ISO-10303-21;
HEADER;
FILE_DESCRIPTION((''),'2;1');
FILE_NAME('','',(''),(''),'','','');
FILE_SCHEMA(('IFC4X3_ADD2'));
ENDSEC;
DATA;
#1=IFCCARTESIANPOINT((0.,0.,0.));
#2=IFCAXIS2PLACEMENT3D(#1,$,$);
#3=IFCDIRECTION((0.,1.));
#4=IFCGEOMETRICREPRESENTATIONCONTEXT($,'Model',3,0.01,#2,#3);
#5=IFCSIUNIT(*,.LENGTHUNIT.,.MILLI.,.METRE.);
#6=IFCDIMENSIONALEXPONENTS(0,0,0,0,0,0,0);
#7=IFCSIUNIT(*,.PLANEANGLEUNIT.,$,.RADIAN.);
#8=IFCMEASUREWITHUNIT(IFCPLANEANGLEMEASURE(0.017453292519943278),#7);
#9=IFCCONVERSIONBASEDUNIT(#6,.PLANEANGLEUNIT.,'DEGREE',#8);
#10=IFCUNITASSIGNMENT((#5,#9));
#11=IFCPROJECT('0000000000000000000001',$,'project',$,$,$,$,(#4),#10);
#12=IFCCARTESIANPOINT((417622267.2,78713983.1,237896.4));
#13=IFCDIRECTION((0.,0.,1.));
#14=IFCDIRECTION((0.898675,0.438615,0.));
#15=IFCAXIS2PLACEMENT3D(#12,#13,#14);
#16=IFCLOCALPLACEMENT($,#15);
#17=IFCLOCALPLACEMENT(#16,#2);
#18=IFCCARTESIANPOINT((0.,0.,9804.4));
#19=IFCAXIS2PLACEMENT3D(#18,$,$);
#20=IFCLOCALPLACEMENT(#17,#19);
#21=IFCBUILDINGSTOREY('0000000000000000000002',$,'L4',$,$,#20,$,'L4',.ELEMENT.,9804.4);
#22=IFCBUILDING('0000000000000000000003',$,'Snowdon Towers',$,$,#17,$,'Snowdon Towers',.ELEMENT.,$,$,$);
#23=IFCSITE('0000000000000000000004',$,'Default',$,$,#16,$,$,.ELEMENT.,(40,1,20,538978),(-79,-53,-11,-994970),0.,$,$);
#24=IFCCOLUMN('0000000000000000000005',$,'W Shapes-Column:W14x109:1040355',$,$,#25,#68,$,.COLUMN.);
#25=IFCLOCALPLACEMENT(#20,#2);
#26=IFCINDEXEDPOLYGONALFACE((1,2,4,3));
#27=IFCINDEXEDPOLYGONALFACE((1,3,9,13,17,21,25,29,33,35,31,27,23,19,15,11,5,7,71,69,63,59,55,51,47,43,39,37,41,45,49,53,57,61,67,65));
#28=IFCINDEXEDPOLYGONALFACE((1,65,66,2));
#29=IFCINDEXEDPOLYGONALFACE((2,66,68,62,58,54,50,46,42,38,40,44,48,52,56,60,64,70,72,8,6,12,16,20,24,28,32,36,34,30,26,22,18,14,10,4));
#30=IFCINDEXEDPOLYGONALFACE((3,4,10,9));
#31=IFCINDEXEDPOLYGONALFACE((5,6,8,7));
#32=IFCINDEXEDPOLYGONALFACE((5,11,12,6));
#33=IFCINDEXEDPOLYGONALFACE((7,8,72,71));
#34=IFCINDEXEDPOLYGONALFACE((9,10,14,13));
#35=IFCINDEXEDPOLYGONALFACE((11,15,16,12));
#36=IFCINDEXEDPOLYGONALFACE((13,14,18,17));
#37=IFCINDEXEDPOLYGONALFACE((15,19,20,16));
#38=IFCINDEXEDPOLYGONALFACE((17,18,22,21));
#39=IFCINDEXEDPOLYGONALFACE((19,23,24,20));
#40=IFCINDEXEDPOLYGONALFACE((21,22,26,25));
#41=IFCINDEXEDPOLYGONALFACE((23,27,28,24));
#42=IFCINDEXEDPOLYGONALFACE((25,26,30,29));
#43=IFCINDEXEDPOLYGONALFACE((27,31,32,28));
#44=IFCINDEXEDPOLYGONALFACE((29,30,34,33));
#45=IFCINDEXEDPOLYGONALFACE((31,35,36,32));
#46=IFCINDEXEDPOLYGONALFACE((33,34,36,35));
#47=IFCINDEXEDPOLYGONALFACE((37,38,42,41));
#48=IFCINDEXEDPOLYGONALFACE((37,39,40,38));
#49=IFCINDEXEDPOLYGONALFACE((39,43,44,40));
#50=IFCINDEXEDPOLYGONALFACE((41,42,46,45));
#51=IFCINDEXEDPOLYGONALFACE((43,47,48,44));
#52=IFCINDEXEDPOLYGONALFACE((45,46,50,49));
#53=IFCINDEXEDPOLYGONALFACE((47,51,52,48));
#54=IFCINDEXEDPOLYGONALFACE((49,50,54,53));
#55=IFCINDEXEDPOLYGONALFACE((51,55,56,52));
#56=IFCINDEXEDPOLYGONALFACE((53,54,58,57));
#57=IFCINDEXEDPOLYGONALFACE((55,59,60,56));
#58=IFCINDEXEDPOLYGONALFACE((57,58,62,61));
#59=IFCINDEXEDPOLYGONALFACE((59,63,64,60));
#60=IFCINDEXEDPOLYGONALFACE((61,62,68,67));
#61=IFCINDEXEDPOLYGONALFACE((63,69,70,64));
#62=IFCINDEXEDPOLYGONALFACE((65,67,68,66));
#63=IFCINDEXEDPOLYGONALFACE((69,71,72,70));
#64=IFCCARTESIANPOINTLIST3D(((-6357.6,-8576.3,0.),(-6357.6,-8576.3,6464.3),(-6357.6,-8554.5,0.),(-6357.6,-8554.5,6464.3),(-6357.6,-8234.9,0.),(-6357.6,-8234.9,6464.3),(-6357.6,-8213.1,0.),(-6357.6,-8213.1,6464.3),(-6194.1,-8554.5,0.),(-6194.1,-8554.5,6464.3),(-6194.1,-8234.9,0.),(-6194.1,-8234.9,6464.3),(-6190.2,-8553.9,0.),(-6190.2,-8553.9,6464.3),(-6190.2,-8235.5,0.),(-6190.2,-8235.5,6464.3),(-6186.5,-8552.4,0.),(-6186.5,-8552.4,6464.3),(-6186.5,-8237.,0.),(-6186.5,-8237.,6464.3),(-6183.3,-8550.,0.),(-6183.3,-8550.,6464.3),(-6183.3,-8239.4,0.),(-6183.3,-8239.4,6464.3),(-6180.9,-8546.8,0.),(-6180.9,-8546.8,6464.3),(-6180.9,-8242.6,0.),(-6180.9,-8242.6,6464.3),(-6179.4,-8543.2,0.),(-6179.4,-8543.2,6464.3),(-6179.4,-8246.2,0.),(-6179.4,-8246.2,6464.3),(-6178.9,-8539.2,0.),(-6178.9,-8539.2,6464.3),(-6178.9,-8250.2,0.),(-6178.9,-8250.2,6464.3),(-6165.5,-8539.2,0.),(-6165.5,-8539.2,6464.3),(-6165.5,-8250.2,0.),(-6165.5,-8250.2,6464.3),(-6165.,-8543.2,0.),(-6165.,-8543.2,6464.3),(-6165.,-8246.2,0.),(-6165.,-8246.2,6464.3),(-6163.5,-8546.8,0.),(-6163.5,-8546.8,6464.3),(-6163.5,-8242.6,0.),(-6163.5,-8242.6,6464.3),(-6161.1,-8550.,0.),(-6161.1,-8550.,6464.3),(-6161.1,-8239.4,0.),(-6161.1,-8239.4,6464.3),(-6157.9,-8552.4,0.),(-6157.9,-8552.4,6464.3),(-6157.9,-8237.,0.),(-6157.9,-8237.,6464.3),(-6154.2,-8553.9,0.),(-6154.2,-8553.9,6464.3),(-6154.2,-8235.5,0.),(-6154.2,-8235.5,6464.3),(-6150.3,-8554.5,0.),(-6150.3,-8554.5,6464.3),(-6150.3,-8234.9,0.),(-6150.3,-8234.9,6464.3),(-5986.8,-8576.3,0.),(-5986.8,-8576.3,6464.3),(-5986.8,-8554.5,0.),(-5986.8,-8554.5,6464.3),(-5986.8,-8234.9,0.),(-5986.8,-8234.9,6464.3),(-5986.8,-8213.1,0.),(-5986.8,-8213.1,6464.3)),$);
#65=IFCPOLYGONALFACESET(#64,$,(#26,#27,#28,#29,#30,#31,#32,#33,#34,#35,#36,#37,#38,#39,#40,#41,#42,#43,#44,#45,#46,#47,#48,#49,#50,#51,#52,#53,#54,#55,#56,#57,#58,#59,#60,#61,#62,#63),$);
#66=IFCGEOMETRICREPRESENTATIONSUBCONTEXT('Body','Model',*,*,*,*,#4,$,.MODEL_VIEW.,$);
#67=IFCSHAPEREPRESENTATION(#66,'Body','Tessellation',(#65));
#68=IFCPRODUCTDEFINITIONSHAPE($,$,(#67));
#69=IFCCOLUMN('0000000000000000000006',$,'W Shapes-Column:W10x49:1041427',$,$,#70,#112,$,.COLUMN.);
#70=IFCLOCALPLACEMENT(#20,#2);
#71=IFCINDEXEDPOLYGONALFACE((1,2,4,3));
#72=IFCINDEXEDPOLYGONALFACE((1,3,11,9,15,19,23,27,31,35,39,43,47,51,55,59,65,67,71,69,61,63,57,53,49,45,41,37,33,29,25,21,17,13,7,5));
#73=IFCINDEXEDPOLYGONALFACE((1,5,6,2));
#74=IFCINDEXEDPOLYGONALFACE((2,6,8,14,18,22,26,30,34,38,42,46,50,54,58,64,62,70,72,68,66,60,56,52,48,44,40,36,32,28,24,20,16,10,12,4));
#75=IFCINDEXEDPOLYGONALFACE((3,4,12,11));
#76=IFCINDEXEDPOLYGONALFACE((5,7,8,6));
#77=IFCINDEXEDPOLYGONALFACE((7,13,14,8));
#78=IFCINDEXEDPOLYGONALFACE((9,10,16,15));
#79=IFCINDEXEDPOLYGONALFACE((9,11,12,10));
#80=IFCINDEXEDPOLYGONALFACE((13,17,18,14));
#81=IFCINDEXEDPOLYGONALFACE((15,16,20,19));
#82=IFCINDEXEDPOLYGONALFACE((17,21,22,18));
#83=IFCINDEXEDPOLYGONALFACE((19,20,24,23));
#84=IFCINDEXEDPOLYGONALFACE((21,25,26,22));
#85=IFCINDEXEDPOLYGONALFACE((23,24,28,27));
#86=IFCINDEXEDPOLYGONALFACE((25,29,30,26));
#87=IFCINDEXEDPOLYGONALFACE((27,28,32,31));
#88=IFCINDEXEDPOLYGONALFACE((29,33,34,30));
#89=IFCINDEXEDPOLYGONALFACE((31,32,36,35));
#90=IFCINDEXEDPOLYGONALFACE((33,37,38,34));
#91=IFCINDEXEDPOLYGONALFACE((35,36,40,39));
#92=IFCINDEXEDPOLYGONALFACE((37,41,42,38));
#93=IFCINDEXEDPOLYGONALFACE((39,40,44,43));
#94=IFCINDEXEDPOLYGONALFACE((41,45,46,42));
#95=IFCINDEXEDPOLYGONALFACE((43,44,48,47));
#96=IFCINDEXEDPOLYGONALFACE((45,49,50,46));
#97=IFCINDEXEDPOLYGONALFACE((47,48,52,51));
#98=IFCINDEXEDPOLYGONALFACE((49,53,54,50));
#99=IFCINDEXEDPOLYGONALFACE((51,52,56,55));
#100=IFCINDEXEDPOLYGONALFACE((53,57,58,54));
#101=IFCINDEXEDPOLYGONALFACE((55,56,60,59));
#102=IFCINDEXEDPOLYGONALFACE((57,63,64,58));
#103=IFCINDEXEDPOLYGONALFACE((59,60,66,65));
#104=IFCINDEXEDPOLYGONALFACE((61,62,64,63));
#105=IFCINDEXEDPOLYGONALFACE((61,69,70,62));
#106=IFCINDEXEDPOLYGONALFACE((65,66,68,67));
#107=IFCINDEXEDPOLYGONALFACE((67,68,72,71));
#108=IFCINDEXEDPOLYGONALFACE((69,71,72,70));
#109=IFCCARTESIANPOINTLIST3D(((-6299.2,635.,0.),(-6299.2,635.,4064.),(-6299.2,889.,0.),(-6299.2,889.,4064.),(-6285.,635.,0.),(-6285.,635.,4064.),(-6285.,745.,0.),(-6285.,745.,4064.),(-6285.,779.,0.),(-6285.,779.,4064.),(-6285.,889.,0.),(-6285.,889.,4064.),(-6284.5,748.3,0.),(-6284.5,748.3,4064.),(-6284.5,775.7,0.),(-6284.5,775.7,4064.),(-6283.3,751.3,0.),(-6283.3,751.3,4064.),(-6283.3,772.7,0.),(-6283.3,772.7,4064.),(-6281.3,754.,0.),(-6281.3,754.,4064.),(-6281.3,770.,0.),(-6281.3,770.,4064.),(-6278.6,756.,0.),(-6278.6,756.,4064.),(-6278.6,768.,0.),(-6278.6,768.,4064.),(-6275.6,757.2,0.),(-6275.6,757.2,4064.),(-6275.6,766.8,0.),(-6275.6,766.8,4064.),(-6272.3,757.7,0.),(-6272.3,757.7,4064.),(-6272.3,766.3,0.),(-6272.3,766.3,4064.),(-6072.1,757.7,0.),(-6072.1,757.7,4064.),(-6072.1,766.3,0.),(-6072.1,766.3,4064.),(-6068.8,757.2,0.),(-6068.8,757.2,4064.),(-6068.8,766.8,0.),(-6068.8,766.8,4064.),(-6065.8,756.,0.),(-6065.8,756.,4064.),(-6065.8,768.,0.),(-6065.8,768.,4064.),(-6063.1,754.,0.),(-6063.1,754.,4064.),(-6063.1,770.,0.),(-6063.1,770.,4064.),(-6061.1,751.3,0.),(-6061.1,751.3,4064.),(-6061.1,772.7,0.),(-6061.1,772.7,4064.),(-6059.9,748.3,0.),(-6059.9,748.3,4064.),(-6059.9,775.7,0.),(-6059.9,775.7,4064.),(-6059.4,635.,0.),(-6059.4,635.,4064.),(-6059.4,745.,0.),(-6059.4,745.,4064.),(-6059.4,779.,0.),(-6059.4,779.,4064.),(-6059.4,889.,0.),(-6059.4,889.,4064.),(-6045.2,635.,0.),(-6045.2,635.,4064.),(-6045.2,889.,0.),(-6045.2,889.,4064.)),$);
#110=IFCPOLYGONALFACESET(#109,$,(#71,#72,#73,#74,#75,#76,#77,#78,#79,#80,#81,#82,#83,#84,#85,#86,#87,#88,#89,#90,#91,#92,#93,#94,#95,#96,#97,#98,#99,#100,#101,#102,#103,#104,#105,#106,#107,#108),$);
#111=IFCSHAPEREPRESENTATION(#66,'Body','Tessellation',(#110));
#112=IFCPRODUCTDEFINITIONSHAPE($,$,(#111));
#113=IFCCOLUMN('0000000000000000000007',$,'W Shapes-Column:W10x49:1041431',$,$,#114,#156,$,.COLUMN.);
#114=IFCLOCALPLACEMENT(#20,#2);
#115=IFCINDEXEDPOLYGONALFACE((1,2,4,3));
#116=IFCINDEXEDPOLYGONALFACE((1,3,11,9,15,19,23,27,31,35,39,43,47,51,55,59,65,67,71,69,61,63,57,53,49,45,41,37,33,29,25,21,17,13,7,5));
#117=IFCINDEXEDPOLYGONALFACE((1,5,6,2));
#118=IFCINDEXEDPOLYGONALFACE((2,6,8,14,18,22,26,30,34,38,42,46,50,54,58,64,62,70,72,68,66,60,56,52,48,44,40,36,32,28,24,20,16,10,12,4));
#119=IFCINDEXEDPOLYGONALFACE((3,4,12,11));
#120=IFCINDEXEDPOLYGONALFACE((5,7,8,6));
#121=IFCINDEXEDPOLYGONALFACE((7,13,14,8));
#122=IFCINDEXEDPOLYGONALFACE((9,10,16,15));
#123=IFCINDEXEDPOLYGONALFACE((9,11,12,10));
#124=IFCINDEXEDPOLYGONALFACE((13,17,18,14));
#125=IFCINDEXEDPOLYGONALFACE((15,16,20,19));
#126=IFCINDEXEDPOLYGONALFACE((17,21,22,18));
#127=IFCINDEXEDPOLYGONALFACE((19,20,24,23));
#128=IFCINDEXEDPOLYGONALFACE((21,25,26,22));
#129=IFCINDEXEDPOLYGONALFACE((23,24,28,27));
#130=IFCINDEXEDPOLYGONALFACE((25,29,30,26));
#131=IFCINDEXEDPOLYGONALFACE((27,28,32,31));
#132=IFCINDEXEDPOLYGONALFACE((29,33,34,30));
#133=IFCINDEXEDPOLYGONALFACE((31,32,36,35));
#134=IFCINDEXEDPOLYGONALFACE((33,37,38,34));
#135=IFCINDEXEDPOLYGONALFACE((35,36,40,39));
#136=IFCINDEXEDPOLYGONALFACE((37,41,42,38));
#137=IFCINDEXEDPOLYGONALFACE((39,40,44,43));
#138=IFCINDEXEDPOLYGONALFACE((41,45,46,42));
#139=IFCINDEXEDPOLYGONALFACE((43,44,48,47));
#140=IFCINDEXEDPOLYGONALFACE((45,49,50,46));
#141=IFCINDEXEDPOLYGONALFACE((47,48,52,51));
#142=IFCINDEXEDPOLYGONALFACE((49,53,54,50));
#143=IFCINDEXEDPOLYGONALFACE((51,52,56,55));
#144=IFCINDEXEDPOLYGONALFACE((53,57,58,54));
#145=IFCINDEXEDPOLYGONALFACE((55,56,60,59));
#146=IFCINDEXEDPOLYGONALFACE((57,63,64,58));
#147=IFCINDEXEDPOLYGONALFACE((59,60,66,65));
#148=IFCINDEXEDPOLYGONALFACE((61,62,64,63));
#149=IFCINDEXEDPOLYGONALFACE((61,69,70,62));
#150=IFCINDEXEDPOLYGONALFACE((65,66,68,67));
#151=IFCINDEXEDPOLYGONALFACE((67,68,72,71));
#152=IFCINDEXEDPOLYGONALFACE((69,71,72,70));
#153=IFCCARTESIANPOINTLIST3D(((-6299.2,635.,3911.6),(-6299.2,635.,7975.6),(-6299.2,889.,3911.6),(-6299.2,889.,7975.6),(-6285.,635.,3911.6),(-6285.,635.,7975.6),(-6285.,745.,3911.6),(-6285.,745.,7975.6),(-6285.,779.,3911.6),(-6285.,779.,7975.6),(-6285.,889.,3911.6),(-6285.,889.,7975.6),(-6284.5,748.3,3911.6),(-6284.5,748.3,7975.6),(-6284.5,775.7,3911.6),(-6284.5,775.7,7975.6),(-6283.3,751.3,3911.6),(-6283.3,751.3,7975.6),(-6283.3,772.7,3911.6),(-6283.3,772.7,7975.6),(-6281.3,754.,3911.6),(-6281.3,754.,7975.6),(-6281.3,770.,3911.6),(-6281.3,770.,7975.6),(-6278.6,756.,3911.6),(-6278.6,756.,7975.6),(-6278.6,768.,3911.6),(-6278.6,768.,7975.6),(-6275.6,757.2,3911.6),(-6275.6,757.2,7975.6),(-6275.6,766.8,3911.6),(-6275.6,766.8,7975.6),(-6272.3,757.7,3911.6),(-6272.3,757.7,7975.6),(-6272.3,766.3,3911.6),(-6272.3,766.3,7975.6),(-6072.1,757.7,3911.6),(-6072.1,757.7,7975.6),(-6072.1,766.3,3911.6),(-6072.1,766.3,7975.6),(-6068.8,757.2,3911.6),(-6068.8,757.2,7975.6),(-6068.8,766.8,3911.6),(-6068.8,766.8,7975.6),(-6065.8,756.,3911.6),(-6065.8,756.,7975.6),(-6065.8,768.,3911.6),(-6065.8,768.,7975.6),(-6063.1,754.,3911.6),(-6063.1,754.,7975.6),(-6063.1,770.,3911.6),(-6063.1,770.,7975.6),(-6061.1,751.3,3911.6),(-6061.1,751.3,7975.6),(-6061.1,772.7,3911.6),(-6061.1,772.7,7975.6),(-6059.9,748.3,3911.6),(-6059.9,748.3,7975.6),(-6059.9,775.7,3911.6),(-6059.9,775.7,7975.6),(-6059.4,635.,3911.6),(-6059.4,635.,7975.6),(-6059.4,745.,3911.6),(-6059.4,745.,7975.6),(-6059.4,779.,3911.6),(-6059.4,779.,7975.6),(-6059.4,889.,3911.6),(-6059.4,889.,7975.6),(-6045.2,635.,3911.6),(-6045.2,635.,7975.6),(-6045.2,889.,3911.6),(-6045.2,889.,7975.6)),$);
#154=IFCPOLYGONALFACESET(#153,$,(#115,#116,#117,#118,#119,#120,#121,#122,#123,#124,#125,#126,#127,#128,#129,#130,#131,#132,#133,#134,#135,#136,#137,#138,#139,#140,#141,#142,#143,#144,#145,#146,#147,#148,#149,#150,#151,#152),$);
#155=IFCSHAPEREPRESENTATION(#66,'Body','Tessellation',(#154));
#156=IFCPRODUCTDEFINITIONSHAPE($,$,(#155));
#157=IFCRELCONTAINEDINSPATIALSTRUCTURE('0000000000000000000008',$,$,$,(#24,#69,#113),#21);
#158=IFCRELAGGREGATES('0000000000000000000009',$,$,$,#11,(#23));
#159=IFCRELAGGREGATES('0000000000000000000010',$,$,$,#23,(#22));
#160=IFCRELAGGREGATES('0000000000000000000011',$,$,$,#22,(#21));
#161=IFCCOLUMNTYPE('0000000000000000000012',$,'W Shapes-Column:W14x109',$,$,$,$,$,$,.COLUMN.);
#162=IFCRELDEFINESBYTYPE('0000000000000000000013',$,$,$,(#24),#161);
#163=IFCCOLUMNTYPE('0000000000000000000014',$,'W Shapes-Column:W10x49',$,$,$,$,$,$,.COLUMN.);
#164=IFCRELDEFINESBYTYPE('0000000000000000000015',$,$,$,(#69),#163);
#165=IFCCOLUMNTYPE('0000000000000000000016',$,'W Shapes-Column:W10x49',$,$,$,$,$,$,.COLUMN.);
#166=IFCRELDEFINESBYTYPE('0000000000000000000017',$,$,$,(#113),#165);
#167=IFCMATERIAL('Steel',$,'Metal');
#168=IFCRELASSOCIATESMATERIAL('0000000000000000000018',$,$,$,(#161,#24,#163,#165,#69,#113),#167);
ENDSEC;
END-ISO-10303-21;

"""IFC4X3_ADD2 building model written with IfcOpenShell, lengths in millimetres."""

from ifc_helpers import new_model, entity, si_unit, converted_unit, direction, frame, frame_2d, origin, place, context, subcontext, project, spatial, i_section, extrude, source, transform, mapped, material, material_profile, profile_set, profile_usage, type_object, type_shapes, element, save


model = new_model("IFC4X3_ADD2")

# Units and contexts
model_context = context("Model", 3, precision=0.01, world=origin(), true_north=direction((0.0, 1.0)))
body_context = subcontext(model_context, "Body", "Model", "MODEL_VIEW")
ifc_project = project(units=[si_unit("LENGTHUNIT", "METRE", prefix="MILLI"), converted_unit("PLANEANGLEUNIT", "DEGREE", entity("IfcPlaneAngleMeasure", 0.017453292519943278), si_unit("PLANEANGLEUNIT", "RADIAN"), dimensions=[0, 0, 0, 0, 0, 0, 0])], contexts=[model_context])

# Site, building, storey
site_placement = place(None, frame((417622267.2, 78713983.1, 237896.4), z_axis=(0.0, 0.0, 1.0), x_axis=(0.898675, 0.438615, 0.0)))
site = spatial("IfcSite", under=ifc_project, at=site_placement, Name="Default", CompositionType="ELEMENT", RefLatitude=(40, 1, 20, 538978), RefLongitude=(-79, -53, -11, -994970), RefElevation=0.0)
building_placement = place(site_placement, origin())
building = spatial("IfcBuilding", under=site, at=building_placement, Name="Snowdon Towers", LongName="Snowdon Towers", CompositionType="ELEMENT")
storey_placement = place(building_placement, frame((0.0, 0.0, 9804.4)))
storey = spatial("IfcBuildingStorey", under=building, at=storey_placement, Name="L4", LongName="L4", CompositionType="ELEMENT", Elevation=9804.4)

# Columns
ifc_material_1 = material(Name="Steel", Category="Metal")
ifc_material_profile_1 = material_profile(ifc_material_1, i_section(OverallWidth=370.8, OverallDepth=363.2, WebThickness=13.3, FlangeThickness=21.8, FilletRadius=15.2, at=frame_2d((0.0, 0.0), x_axis=(1.0, 0.0))), Name="W14x109")
ifc_profile_set_1 = profile_set([ifc_material_profile_1], Name="W14x109")
ifc_profile_usage_1 = profile_usage(ifc_profile_set_1)
column_type_1 = type_object("IfcColumnType", Name="W Shapes-Column:W14x109", PredefinedType="COLUMN", material=ifc_profile_set_1)
shared_shape_1 = source(origin(), body_context, "Body", "SweptSolid", [
    extrude(i_section(OverallWidth=370.8, OverallDepth=363.2, WebThickness=13.3, FlangeThickness=21.8, FilletRadius=15.2, at=frame_2d((0.0, 0.0), x_axis=(1.0, 0.0))), frame((0.0, 0.0, 9804.4), z_axis=(0.0, 0.0, 1.0), x_axis=(-1.0, 0.0, 0.0)), (0.0, 0.0, 1.0), 6464.3),
])
type_shapes(column_type_1, [shared_shape_1])
column_1_placement = place(storey_placement, frame((-6172.2, -8394.7, -9804.4), z_axis=(0.0, 0.0, 1.0), x_axis=(-1.0, 0.0, 0.0)))
element("IfcColumn", 1, at=column_1_placement, inside=storey, type_object=column_type_1, material=ifc_profile_usage_1, Name="W Shapes-Column:W14x109:1040355", PredefinedType="COLUMN", context=body_context, shape_type="MappedRepresentation", body=[
    mapped(shared_shape_1, transform((0.0, 0.0, 0.0), scale=1.0)),
])
ifc_material_profile_2 = material_profile(ifc_material_1, i_section(OverallWidth=254.0, OverallDepth=254.0, WebThickness=8.6, FlangeThickness=14.2, FilletRadius=12.7, at=frame_2d((0.0, 0.0), x_axis=(1.0, 0.0))), Name="W10x49")
ifc_profile_set_2 = profile_set([ifc_material_profile_2], Name="W10x49")
ifc_profile_usage_2 = profile_usage(ifc_profile_set_2)
column_type_2 = type_object("IfcColumnType", Name="W Shapes-Column:W10x49", PredefinedType="COLUMN", material=ifc_profile_set_2)
shared_shape_2 = source(origin(), body_context, "Body", "SweptSolid", [
    extrude(i_section(OverallWidth=254.0, OverallDepth=254.0, WebThickness=8.6, FlangeThickness=14.2, FilletRadius=12.7, at=frame_2d((0.0, 0.0), x_axis=(1.0, 0.0))), frame((0.0, 0.0, 9804.4), z_axis=(0.0, 0.0, 1.0), x_axis=(-1.0, 0.0, 0.0)), (0.0, 0.0, 1.0), 4064.0),
])
type_shapes(column_type_2, [shared_shape_2])
column_2_placement = place(storey_placement, frame((-6172.2, 762.0, -9804.4), z_axis=(0.0, 0.0, 1.0), x_axis=(0.0, 1.0, 0.0)))
element("IfcColumn", 2, at=column_2_placement, inside=storey, type_object=column_type_2, material=ifc_profile_usage_2, Name="W Shapes-Column:W10x49:1041427", PredefinedType="COLUMN", context=body_context, shape_type="MappedRepresentation", body=[
    mapped(shared_shape_2, transform((0.0, 0.0, 0.0), scale=1.0)),
])
column_type_3 = type_object("IfcColumnType", Name="W Shapes-Column:W10x49", PredefinedType="COLUMN", material=ifc_profile_set_2)
shared_shape_3 = source(origin(), body_context, "Body", "SweptSolid", [
    extrude(i_section(OverallWidth=254.0, OverallDepth=254.0, WebThickness=8.6, FlangeThickness=14.2, FilletRadius=12.7, at=frame_2d((0.0, 0.0), x_axis=(1.0, 0.0))), frame((0.0, 0.0, 13716.0), z_axis=(0.0, 0.0, 1.0), x_axis=(-1.0, 0.0, 0.0)), (0.0, 0.0, 1.0), 4064.0),
])
type_shapes(column_type_3, [shared_shape_3])
column_3_placement = place(storey_placement, frame((-6172.2, 762.0, -9804.4), z_axis=(0.0, 0.0, 1.0), x_axis=(0.0, 1.0, 0.0)))
element("IfcColumn", 3, at=column_3_placement, inside=storey, type_object=column_type_3, material=ifc_profile_usage_2, Name="W Shapes-Column:W10x49:1041431", PredefinedType="COLUMN", context=body_context, shape_type="MappedRepresentation", body=[
    mapped(shared_shape_3, transform((0.0, 0.0, 0.0), scale=1.0)),
])

save(model, "model.ifc")
